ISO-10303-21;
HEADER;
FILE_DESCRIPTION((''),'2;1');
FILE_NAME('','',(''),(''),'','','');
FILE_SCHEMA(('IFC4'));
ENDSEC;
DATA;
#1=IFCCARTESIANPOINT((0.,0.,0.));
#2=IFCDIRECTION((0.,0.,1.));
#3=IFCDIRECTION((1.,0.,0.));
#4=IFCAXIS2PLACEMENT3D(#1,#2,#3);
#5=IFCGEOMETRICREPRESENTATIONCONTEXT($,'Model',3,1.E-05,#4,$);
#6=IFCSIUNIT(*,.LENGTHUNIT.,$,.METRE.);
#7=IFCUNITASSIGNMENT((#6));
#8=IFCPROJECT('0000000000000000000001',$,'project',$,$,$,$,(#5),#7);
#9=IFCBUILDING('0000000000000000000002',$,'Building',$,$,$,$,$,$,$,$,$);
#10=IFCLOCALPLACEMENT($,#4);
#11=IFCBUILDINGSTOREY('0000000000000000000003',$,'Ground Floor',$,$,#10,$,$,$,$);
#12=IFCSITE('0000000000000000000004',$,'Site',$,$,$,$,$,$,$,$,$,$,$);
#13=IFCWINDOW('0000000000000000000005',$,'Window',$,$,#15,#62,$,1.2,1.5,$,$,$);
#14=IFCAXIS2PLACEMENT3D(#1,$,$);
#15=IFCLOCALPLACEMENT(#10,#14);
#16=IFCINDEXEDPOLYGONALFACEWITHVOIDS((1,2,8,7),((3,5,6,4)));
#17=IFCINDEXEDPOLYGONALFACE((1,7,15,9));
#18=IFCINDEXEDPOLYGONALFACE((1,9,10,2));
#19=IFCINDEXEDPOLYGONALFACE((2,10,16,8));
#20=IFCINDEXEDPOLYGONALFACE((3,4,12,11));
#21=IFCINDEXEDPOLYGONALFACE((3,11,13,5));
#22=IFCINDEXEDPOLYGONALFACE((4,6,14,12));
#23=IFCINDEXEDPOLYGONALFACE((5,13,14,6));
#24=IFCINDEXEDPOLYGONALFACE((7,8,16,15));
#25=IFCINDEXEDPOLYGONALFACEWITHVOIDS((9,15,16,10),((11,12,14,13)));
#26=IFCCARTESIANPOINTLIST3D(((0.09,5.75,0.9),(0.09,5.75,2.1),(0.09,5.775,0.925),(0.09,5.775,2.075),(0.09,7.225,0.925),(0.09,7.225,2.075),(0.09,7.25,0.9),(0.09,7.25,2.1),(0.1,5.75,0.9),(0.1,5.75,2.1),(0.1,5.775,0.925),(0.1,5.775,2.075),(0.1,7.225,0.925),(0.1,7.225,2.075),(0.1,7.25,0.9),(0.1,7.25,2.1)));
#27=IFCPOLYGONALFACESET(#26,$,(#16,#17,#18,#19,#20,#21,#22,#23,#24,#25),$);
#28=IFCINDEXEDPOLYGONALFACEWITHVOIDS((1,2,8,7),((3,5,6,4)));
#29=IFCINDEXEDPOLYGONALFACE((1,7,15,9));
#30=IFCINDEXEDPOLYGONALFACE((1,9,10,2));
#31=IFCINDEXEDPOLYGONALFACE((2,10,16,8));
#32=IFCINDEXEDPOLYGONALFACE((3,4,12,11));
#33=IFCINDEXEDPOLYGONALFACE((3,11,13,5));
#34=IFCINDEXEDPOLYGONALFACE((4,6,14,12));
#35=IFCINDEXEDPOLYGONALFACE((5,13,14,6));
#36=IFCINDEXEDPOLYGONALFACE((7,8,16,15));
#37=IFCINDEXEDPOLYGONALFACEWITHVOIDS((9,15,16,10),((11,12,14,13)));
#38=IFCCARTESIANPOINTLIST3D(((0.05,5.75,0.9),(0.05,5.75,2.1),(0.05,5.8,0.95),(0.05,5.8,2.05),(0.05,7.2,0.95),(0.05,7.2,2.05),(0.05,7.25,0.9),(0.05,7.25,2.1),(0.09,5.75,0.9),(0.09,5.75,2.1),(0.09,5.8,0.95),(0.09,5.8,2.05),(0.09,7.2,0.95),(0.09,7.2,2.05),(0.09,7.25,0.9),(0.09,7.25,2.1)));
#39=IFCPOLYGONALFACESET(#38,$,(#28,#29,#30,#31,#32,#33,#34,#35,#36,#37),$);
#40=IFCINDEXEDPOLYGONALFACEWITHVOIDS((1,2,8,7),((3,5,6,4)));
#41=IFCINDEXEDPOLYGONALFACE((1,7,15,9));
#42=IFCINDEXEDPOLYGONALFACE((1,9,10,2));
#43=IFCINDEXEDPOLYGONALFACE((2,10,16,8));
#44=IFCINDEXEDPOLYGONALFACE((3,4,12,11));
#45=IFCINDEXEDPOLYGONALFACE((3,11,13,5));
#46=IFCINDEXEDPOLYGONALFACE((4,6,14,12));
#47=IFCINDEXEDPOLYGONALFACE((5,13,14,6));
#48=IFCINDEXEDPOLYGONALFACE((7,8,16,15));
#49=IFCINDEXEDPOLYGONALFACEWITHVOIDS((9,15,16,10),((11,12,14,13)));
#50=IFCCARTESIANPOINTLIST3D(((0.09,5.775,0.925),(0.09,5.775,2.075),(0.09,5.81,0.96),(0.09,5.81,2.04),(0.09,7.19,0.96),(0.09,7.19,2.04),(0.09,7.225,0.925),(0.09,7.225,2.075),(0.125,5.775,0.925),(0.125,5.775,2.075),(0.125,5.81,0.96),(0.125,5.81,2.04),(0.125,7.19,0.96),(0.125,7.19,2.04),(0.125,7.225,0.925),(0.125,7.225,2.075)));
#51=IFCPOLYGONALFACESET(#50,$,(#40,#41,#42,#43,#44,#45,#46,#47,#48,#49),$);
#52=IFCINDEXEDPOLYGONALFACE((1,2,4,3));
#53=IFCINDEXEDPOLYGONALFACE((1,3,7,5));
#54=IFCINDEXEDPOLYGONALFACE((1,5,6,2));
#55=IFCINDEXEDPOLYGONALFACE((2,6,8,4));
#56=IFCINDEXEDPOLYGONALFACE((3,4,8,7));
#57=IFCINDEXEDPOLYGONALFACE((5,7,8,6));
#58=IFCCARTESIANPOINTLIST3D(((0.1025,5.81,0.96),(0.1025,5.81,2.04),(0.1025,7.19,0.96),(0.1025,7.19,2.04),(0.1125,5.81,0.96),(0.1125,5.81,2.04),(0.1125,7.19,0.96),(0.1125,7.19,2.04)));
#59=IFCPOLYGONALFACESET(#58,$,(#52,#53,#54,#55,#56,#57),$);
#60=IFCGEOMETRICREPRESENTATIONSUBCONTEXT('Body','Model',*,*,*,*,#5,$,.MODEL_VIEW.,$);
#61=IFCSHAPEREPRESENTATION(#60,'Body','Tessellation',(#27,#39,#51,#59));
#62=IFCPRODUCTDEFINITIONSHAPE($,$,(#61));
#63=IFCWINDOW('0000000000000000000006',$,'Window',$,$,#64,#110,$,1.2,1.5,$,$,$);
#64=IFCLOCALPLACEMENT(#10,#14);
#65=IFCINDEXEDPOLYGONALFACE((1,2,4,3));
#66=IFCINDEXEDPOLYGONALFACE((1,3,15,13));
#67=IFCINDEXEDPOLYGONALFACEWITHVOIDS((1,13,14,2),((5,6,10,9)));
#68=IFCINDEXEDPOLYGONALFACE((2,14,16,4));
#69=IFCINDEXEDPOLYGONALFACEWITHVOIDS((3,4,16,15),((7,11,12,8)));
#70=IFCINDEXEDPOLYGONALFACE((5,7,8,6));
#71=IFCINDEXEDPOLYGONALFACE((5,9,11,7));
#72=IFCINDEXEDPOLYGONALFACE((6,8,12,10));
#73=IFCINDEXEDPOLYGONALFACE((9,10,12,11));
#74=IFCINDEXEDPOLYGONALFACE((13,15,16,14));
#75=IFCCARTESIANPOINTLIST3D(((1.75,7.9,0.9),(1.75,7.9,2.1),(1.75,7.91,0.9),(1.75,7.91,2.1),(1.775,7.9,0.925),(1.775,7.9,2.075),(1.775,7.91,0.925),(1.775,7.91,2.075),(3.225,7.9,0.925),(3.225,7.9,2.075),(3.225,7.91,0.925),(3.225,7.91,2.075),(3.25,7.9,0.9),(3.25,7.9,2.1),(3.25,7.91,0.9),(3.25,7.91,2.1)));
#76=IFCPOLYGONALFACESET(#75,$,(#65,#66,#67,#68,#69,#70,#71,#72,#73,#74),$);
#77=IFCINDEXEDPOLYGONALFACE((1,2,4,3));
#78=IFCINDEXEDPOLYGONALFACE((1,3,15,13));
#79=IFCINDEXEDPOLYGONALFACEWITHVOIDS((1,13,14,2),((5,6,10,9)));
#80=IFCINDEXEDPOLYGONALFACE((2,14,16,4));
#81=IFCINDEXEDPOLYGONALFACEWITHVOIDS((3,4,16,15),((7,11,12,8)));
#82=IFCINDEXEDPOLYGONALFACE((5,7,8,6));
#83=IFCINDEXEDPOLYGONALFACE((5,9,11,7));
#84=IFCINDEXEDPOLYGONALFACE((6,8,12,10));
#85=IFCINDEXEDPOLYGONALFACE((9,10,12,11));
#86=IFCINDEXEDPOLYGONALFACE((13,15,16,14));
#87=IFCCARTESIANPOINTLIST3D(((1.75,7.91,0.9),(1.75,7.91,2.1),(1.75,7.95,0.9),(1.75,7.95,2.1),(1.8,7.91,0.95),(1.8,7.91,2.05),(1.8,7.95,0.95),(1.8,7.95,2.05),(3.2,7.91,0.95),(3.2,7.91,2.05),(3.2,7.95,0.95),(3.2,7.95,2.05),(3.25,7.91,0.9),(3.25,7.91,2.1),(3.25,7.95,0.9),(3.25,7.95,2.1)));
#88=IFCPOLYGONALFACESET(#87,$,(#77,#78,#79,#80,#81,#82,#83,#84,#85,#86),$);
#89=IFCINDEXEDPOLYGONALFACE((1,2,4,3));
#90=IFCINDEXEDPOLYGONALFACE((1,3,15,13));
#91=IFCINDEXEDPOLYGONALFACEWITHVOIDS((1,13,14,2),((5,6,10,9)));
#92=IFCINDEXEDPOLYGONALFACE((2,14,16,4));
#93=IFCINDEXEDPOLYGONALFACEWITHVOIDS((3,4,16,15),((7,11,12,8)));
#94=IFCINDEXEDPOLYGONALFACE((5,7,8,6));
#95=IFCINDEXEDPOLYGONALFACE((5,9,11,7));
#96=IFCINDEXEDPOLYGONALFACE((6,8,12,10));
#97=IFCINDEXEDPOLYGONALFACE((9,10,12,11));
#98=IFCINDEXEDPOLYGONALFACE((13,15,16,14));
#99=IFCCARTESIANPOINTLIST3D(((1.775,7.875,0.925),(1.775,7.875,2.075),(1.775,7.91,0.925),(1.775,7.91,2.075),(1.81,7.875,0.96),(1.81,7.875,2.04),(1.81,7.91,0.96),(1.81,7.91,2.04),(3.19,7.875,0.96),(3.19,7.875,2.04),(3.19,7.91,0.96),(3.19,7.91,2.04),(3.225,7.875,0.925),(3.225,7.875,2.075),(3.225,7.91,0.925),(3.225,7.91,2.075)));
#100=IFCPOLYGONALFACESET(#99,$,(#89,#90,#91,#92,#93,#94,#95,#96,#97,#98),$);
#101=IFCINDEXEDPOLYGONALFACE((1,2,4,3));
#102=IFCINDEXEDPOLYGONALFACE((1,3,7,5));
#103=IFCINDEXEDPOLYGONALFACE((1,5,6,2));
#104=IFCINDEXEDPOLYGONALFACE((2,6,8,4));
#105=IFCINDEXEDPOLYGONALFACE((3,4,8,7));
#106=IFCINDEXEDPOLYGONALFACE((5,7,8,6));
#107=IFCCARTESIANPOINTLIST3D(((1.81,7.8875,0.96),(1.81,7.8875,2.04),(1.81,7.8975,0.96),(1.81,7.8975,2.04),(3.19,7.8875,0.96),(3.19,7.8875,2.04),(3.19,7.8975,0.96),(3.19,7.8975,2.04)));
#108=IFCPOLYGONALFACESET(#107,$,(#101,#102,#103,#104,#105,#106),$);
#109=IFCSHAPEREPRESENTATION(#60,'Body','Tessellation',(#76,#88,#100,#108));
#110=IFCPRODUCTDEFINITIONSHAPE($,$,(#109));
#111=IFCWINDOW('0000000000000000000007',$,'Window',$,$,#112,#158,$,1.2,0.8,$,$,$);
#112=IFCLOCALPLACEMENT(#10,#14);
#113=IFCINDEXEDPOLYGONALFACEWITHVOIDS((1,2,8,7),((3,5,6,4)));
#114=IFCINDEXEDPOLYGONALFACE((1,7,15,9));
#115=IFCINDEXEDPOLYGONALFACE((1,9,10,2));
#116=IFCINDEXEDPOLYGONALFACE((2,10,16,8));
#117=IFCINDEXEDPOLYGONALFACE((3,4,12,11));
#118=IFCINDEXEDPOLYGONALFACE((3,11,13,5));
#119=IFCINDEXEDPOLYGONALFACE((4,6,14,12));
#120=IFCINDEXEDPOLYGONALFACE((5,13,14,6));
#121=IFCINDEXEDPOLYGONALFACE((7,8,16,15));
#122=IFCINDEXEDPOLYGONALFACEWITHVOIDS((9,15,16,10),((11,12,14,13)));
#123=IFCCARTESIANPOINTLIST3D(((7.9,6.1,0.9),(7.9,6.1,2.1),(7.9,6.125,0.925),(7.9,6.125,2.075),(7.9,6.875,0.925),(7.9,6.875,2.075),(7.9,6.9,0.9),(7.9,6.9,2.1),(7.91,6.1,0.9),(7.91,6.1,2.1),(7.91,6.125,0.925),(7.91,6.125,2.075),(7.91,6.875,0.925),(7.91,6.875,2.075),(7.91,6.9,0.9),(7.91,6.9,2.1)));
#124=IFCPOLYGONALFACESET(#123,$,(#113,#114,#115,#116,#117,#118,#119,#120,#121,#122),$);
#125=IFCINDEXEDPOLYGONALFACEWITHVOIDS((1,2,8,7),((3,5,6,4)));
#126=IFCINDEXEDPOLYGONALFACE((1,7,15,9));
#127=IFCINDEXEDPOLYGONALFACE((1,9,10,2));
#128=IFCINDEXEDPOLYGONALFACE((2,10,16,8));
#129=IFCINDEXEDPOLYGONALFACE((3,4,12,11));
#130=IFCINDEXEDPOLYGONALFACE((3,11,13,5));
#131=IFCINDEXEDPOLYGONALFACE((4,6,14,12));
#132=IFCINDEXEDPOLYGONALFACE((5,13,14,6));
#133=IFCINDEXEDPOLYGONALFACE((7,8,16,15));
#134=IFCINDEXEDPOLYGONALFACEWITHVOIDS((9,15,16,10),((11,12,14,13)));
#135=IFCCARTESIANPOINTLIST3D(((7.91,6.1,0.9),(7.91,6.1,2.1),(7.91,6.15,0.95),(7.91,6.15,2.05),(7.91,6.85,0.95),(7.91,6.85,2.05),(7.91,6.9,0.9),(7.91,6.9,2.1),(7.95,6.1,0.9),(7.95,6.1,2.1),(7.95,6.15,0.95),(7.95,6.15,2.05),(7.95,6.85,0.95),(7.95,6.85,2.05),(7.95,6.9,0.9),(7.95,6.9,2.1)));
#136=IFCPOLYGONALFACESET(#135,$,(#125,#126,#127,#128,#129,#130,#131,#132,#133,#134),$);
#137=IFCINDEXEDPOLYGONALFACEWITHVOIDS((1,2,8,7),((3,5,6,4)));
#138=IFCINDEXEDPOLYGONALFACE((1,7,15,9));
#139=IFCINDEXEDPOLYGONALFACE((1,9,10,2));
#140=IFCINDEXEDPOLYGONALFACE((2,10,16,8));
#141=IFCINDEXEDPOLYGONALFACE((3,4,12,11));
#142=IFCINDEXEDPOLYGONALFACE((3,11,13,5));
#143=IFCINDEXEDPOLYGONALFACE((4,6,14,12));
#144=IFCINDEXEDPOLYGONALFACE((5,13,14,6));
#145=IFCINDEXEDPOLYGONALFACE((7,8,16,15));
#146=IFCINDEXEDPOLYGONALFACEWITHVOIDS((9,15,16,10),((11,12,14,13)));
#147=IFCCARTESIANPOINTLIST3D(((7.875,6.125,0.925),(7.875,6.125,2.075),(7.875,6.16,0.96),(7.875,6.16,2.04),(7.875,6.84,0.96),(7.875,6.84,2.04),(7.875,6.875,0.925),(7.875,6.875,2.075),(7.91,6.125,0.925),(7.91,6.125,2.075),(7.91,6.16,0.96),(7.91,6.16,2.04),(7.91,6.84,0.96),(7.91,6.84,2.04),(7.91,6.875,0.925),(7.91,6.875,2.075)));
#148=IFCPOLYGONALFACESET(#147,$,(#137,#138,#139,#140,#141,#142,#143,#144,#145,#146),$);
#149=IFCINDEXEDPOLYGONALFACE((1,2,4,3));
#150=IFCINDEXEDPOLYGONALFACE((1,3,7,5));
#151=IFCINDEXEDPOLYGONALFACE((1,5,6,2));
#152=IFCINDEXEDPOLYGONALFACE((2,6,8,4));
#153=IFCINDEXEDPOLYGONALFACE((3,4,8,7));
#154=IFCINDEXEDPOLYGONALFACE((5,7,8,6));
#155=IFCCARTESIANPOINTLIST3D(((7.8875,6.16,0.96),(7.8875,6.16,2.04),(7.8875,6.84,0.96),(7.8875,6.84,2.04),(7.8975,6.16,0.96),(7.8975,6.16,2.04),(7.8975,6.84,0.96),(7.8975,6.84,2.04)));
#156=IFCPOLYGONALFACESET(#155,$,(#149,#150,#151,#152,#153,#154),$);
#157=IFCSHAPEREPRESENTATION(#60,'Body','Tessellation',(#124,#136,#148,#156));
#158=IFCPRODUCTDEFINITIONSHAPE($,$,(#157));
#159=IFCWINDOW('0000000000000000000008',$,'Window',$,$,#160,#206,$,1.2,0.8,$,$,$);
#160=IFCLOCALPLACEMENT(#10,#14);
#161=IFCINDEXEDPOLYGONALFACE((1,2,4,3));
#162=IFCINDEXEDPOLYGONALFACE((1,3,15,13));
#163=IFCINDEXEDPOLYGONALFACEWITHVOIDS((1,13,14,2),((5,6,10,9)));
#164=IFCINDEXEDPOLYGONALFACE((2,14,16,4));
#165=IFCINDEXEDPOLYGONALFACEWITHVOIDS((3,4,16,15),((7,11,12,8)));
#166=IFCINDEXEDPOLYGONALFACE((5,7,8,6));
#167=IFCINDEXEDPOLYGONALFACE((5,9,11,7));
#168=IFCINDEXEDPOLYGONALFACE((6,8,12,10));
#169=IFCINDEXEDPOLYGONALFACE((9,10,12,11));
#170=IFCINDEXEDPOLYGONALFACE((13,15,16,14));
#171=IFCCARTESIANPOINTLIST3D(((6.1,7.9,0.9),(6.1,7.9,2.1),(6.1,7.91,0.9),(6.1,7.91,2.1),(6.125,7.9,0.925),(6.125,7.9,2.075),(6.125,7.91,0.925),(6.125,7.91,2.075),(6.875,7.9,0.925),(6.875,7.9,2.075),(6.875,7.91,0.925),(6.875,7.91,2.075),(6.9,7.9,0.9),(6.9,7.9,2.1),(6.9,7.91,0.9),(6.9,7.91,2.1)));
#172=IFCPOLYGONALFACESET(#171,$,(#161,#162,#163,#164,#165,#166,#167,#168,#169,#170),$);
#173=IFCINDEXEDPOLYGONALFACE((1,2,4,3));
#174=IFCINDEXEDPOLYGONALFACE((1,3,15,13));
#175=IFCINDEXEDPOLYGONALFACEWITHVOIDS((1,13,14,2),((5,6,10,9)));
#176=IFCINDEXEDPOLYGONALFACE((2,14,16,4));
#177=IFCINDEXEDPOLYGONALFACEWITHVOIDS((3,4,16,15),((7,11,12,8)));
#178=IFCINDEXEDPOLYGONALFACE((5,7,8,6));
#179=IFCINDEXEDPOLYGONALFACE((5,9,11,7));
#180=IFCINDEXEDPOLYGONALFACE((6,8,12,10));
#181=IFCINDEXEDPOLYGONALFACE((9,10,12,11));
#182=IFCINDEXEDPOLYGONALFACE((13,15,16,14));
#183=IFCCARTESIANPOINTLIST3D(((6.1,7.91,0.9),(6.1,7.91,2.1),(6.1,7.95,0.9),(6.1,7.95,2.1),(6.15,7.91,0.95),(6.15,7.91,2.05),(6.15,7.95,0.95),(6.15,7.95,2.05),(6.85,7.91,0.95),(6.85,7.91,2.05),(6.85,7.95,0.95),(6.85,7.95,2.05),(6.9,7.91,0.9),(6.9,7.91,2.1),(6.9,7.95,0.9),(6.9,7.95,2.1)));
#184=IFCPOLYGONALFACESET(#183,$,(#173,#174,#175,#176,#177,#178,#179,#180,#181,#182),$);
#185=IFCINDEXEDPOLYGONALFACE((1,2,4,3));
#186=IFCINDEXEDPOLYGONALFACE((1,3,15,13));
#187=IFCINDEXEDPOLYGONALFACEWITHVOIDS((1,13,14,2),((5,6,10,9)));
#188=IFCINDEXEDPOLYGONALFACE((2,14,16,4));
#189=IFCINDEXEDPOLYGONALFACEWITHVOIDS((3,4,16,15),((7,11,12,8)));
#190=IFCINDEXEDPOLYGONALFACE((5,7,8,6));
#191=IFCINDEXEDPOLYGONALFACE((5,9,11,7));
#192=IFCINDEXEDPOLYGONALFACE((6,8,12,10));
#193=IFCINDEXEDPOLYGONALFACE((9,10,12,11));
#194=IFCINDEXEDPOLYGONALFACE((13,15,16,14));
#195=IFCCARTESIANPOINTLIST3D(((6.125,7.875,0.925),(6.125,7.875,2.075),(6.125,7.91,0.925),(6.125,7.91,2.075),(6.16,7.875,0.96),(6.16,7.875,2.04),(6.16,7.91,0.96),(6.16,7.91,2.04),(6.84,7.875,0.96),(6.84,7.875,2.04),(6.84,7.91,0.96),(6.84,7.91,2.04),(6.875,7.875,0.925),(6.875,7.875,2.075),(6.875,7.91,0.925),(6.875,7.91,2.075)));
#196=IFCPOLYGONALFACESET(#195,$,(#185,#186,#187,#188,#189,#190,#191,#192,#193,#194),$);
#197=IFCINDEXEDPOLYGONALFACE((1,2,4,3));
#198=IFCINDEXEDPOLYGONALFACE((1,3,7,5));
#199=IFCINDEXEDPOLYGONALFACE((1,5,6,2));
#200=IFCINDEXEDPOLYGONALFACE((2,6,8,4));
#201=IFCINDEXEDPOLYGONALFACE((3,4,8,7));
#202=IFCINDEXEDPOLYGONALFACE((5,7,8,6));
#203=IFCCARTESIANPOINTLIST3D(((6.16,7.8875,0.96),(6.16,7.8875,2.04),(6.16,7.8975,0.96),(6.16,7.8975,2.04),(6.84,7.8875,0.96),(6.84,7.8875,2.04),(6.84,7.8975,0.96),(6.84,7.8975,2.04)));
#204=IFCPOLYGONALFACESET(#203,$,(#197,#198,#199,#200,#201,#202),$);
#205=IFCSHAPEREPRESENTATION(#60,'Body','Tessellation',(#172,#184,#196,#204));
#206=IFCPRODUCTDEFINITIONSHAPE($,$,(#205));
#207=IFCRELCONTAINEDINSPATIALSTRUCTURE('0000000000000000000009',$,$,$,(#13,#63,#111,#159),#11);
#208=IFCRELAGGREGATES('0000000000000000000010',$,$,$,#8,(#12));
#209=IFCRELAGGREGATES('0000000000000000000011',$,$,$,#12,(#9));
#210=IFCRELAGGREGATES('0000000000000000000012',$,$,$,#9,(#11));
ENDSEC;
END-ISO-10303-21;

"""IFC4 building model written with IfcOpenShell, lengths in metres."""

from ifc_helpers import new_model, si_unit, frame, origin_with_axes, place, context, subcontext, project, spatial, line, indexed_curve, outline, extrude, element, save


model = new_model("IFC4")

# Units and contexts
model_context = context("Model", 3, precision=1e-05, world=origin_with_axes())
body_context = subcontext(model_context, "Body", "Model", "MODEL_VIEW")
ifc_project = project(units=[si_unit("LENGTHUNIT", "METRE")], contexts=[model_context])

# Site, building, storey
site = spatial("IfcSite", under=ifc_project, Name="Site")
building = spatial("IfcBuilding", under=site, Name="Building")
storey_placement = place(None, origin_with_axes())
storey = spatial("IfcBuildingStorey", under=building, at=storey_placement, Name="Ground Floor")

# Windows
for number, where, z_axis, x_axis, name in (
    (1, (0.0, 7.25, 0.9), (0.0, 0.0, 1.0), (0.0, -1.0, 0.0), "Window"),
    (2, (3.25, 8.0, 0.9), (0.0, 0.0, 1.0), (-1.0, 0.0, 0.0), "Window"),
):
    element("IfcWindow", number, at=place(storey_placement, frame(where, z_axis=z_axis, x_axis=x_axis)), inside=storey, Name=name, OverallHeight=1.2, OverallWidth=1.5, context=body_context, shape_type="SweptSolid", body=[
        extrude(outline(indexed_curve([(0.0, 0.0), (1.5, 0.0), (1.5, 1.2), (0.0, 1.2)], segments=[line(1, 2, 3, 4, 1)]), holes=[indexed_curve([(0.025, 0.025), (1.475, 0.025), (1.475, 1.175), (0.025, 1.175)], segments=[line(1, 2, 3, 4, 1)])]), frame((0.0, 0.09, 0.0), z_axis=(0.0, -1.0, 0.0), x_axis=(1.0, 0.0, 0.0)), (0.0, 0.0, -1.0), 0.01),
        extrude(outline(indexed_curve([(0.0, 0.0), (1.5, 0.0), (1.5, 1.2), (0.0, 1.2)], segments=[line(1, 2, 3, 4, 1)]), holes=[indexed_curve([(0.05, 0.05), (1.45, 0.05), (1.45, 1.15), (0.05, 1.15)], segments=[line(1, 2, 3, 4, 1)])]), frame((0.0, 0.05, 0.0), z_axis=(0.0, -1.0, 0.0), x_axis=(1.0, 0.0, 0.0)), (0.0, 0.0, -1.0), 0.04),
        extrude(outline(indexed_curve([(0.0, 0.0), (1.45, 0.0), (1.45, 1.15), (0.0, 1.15)], segments=[line(1, 2, 3, 4, 1)]), holes=[indexed_curve([(0.035, 0.035), (1.415, 0.035), (1.415, 1.115), (0.035, 1.115)], segments=[line(1, 2, 3, 4, 1)])]), frame((0.025, 0.09, 0.025), z_axis=(0.0, -1.0, 0.0), x_axis=(1.0, 0.0, 0.0)), (0.0, 0.0, -1.0), 0.035),
        extrude(outline(indexed_curve([(0.035, 0.035), (1.415, 0.035), (1.415, 1.115), (0.035, 1.115)], segments=[line(1, 2, 3, 4, 1)])), frame((0.025, 0.1025, 0.025), z_axis=(0.0, -1.0, 0.0), x_axis=(1.0, 0.0, 0.0)), (0.0, 0.0, -1.0), 0.01),
    ])
for number, where, z_axis, x_axis, name in (
    (3, (8.0, 6.1, 0.9), (0.0, 0.0, 1.0), (0.0, 1.0, 0.0), "Window"),
    (4, (6.9, 8.0, 0.9), (0.0, 0.0, 1.0), (-1.0, 0.0, 0.0), "Window"),
):
    element("IfcWindow", number, at=place(storey_placement, frame(where, z_axis=z_axis, x_axis=x_axis)), inside=storey, Name=name, OverallHeight=1.2, OverallWidth=0.8, context=body_context, shape_type="SweptSolid", body=[
        extrude(outline(indexed_curve([(0.0, 0.0), (0.8, 0.0), (0.8, 1.2), (0.0, 1.2)], segments=[line(1, 2, 3, 4, 1)]), holes=[indexed_curve([(0.025, 0.025), (0.775, 0.025), (0.775, 1.175), (0.025, 1.175)], segments=[line(1, 2, 3, 4, 1)])]), frame((0.0, 0.09, 0.0), z_axis=(0.0, -1.0, 0.0), x_axis=(1.0, 0.0, 0.0)), (0.0, 0.0, -1.0), 0.01),
        extrude(outline(indexed_curve([(0.0, 0.0), (0.8, 0.0), (0.8, 1.2), (0.0, 1.2)], segments=[line(1, 2, 3, 4, 1)]), holes=[indexed_curve([(0.05, 0.05), (0.75, 0.05), (0.75, 1.15), (0.05, 1.15)], segments=[line(1, 2, 3, 4, 1)])]), frame((0.0, 0.05, 0.0), z_axis=(0.0, -1.0, 0.0), x_axis=(1.0, 0.0, 0.0)), (0.0, 0.0, -1.0), 0.04),
        extrude(outline(indexed_curve([(0.0, 0.0), (0.75, 0.0), (0.75, 1.15), (0.0, 1.15)], segments=[line(1, 2, 3, 4, 1)]), holes=[indexed_curve([(0.035, 0.035), (0.715, 0.035), (0.715, 1.115), (0.035, 1.115)], segments=[line(1, 2, 3, 4, 1)])]), frame((0.025, 0.09, 0.025), z_axis=(0.0, -1.0, 0.0), x_axis=(1.0, 0.0, 0.0)), (0.0, 0.0, -1.0), 0.035),
        extrude(outline(indexed_curve([(0.035, 0.035), (0.715, 0.035), (0.715, 1.115), (0.035, 1.115)], segments=[line(1, 2, 3, 4, 1)])), frame((0.025, 0.1025, 0.025), z_axis=(0.0, -1.0, 0.0), x_axis=(1.0, 0.0, 0.0)), (0.0, 0.0, -1.0), 0.01),
    ])

save(model, "model.ifc")
